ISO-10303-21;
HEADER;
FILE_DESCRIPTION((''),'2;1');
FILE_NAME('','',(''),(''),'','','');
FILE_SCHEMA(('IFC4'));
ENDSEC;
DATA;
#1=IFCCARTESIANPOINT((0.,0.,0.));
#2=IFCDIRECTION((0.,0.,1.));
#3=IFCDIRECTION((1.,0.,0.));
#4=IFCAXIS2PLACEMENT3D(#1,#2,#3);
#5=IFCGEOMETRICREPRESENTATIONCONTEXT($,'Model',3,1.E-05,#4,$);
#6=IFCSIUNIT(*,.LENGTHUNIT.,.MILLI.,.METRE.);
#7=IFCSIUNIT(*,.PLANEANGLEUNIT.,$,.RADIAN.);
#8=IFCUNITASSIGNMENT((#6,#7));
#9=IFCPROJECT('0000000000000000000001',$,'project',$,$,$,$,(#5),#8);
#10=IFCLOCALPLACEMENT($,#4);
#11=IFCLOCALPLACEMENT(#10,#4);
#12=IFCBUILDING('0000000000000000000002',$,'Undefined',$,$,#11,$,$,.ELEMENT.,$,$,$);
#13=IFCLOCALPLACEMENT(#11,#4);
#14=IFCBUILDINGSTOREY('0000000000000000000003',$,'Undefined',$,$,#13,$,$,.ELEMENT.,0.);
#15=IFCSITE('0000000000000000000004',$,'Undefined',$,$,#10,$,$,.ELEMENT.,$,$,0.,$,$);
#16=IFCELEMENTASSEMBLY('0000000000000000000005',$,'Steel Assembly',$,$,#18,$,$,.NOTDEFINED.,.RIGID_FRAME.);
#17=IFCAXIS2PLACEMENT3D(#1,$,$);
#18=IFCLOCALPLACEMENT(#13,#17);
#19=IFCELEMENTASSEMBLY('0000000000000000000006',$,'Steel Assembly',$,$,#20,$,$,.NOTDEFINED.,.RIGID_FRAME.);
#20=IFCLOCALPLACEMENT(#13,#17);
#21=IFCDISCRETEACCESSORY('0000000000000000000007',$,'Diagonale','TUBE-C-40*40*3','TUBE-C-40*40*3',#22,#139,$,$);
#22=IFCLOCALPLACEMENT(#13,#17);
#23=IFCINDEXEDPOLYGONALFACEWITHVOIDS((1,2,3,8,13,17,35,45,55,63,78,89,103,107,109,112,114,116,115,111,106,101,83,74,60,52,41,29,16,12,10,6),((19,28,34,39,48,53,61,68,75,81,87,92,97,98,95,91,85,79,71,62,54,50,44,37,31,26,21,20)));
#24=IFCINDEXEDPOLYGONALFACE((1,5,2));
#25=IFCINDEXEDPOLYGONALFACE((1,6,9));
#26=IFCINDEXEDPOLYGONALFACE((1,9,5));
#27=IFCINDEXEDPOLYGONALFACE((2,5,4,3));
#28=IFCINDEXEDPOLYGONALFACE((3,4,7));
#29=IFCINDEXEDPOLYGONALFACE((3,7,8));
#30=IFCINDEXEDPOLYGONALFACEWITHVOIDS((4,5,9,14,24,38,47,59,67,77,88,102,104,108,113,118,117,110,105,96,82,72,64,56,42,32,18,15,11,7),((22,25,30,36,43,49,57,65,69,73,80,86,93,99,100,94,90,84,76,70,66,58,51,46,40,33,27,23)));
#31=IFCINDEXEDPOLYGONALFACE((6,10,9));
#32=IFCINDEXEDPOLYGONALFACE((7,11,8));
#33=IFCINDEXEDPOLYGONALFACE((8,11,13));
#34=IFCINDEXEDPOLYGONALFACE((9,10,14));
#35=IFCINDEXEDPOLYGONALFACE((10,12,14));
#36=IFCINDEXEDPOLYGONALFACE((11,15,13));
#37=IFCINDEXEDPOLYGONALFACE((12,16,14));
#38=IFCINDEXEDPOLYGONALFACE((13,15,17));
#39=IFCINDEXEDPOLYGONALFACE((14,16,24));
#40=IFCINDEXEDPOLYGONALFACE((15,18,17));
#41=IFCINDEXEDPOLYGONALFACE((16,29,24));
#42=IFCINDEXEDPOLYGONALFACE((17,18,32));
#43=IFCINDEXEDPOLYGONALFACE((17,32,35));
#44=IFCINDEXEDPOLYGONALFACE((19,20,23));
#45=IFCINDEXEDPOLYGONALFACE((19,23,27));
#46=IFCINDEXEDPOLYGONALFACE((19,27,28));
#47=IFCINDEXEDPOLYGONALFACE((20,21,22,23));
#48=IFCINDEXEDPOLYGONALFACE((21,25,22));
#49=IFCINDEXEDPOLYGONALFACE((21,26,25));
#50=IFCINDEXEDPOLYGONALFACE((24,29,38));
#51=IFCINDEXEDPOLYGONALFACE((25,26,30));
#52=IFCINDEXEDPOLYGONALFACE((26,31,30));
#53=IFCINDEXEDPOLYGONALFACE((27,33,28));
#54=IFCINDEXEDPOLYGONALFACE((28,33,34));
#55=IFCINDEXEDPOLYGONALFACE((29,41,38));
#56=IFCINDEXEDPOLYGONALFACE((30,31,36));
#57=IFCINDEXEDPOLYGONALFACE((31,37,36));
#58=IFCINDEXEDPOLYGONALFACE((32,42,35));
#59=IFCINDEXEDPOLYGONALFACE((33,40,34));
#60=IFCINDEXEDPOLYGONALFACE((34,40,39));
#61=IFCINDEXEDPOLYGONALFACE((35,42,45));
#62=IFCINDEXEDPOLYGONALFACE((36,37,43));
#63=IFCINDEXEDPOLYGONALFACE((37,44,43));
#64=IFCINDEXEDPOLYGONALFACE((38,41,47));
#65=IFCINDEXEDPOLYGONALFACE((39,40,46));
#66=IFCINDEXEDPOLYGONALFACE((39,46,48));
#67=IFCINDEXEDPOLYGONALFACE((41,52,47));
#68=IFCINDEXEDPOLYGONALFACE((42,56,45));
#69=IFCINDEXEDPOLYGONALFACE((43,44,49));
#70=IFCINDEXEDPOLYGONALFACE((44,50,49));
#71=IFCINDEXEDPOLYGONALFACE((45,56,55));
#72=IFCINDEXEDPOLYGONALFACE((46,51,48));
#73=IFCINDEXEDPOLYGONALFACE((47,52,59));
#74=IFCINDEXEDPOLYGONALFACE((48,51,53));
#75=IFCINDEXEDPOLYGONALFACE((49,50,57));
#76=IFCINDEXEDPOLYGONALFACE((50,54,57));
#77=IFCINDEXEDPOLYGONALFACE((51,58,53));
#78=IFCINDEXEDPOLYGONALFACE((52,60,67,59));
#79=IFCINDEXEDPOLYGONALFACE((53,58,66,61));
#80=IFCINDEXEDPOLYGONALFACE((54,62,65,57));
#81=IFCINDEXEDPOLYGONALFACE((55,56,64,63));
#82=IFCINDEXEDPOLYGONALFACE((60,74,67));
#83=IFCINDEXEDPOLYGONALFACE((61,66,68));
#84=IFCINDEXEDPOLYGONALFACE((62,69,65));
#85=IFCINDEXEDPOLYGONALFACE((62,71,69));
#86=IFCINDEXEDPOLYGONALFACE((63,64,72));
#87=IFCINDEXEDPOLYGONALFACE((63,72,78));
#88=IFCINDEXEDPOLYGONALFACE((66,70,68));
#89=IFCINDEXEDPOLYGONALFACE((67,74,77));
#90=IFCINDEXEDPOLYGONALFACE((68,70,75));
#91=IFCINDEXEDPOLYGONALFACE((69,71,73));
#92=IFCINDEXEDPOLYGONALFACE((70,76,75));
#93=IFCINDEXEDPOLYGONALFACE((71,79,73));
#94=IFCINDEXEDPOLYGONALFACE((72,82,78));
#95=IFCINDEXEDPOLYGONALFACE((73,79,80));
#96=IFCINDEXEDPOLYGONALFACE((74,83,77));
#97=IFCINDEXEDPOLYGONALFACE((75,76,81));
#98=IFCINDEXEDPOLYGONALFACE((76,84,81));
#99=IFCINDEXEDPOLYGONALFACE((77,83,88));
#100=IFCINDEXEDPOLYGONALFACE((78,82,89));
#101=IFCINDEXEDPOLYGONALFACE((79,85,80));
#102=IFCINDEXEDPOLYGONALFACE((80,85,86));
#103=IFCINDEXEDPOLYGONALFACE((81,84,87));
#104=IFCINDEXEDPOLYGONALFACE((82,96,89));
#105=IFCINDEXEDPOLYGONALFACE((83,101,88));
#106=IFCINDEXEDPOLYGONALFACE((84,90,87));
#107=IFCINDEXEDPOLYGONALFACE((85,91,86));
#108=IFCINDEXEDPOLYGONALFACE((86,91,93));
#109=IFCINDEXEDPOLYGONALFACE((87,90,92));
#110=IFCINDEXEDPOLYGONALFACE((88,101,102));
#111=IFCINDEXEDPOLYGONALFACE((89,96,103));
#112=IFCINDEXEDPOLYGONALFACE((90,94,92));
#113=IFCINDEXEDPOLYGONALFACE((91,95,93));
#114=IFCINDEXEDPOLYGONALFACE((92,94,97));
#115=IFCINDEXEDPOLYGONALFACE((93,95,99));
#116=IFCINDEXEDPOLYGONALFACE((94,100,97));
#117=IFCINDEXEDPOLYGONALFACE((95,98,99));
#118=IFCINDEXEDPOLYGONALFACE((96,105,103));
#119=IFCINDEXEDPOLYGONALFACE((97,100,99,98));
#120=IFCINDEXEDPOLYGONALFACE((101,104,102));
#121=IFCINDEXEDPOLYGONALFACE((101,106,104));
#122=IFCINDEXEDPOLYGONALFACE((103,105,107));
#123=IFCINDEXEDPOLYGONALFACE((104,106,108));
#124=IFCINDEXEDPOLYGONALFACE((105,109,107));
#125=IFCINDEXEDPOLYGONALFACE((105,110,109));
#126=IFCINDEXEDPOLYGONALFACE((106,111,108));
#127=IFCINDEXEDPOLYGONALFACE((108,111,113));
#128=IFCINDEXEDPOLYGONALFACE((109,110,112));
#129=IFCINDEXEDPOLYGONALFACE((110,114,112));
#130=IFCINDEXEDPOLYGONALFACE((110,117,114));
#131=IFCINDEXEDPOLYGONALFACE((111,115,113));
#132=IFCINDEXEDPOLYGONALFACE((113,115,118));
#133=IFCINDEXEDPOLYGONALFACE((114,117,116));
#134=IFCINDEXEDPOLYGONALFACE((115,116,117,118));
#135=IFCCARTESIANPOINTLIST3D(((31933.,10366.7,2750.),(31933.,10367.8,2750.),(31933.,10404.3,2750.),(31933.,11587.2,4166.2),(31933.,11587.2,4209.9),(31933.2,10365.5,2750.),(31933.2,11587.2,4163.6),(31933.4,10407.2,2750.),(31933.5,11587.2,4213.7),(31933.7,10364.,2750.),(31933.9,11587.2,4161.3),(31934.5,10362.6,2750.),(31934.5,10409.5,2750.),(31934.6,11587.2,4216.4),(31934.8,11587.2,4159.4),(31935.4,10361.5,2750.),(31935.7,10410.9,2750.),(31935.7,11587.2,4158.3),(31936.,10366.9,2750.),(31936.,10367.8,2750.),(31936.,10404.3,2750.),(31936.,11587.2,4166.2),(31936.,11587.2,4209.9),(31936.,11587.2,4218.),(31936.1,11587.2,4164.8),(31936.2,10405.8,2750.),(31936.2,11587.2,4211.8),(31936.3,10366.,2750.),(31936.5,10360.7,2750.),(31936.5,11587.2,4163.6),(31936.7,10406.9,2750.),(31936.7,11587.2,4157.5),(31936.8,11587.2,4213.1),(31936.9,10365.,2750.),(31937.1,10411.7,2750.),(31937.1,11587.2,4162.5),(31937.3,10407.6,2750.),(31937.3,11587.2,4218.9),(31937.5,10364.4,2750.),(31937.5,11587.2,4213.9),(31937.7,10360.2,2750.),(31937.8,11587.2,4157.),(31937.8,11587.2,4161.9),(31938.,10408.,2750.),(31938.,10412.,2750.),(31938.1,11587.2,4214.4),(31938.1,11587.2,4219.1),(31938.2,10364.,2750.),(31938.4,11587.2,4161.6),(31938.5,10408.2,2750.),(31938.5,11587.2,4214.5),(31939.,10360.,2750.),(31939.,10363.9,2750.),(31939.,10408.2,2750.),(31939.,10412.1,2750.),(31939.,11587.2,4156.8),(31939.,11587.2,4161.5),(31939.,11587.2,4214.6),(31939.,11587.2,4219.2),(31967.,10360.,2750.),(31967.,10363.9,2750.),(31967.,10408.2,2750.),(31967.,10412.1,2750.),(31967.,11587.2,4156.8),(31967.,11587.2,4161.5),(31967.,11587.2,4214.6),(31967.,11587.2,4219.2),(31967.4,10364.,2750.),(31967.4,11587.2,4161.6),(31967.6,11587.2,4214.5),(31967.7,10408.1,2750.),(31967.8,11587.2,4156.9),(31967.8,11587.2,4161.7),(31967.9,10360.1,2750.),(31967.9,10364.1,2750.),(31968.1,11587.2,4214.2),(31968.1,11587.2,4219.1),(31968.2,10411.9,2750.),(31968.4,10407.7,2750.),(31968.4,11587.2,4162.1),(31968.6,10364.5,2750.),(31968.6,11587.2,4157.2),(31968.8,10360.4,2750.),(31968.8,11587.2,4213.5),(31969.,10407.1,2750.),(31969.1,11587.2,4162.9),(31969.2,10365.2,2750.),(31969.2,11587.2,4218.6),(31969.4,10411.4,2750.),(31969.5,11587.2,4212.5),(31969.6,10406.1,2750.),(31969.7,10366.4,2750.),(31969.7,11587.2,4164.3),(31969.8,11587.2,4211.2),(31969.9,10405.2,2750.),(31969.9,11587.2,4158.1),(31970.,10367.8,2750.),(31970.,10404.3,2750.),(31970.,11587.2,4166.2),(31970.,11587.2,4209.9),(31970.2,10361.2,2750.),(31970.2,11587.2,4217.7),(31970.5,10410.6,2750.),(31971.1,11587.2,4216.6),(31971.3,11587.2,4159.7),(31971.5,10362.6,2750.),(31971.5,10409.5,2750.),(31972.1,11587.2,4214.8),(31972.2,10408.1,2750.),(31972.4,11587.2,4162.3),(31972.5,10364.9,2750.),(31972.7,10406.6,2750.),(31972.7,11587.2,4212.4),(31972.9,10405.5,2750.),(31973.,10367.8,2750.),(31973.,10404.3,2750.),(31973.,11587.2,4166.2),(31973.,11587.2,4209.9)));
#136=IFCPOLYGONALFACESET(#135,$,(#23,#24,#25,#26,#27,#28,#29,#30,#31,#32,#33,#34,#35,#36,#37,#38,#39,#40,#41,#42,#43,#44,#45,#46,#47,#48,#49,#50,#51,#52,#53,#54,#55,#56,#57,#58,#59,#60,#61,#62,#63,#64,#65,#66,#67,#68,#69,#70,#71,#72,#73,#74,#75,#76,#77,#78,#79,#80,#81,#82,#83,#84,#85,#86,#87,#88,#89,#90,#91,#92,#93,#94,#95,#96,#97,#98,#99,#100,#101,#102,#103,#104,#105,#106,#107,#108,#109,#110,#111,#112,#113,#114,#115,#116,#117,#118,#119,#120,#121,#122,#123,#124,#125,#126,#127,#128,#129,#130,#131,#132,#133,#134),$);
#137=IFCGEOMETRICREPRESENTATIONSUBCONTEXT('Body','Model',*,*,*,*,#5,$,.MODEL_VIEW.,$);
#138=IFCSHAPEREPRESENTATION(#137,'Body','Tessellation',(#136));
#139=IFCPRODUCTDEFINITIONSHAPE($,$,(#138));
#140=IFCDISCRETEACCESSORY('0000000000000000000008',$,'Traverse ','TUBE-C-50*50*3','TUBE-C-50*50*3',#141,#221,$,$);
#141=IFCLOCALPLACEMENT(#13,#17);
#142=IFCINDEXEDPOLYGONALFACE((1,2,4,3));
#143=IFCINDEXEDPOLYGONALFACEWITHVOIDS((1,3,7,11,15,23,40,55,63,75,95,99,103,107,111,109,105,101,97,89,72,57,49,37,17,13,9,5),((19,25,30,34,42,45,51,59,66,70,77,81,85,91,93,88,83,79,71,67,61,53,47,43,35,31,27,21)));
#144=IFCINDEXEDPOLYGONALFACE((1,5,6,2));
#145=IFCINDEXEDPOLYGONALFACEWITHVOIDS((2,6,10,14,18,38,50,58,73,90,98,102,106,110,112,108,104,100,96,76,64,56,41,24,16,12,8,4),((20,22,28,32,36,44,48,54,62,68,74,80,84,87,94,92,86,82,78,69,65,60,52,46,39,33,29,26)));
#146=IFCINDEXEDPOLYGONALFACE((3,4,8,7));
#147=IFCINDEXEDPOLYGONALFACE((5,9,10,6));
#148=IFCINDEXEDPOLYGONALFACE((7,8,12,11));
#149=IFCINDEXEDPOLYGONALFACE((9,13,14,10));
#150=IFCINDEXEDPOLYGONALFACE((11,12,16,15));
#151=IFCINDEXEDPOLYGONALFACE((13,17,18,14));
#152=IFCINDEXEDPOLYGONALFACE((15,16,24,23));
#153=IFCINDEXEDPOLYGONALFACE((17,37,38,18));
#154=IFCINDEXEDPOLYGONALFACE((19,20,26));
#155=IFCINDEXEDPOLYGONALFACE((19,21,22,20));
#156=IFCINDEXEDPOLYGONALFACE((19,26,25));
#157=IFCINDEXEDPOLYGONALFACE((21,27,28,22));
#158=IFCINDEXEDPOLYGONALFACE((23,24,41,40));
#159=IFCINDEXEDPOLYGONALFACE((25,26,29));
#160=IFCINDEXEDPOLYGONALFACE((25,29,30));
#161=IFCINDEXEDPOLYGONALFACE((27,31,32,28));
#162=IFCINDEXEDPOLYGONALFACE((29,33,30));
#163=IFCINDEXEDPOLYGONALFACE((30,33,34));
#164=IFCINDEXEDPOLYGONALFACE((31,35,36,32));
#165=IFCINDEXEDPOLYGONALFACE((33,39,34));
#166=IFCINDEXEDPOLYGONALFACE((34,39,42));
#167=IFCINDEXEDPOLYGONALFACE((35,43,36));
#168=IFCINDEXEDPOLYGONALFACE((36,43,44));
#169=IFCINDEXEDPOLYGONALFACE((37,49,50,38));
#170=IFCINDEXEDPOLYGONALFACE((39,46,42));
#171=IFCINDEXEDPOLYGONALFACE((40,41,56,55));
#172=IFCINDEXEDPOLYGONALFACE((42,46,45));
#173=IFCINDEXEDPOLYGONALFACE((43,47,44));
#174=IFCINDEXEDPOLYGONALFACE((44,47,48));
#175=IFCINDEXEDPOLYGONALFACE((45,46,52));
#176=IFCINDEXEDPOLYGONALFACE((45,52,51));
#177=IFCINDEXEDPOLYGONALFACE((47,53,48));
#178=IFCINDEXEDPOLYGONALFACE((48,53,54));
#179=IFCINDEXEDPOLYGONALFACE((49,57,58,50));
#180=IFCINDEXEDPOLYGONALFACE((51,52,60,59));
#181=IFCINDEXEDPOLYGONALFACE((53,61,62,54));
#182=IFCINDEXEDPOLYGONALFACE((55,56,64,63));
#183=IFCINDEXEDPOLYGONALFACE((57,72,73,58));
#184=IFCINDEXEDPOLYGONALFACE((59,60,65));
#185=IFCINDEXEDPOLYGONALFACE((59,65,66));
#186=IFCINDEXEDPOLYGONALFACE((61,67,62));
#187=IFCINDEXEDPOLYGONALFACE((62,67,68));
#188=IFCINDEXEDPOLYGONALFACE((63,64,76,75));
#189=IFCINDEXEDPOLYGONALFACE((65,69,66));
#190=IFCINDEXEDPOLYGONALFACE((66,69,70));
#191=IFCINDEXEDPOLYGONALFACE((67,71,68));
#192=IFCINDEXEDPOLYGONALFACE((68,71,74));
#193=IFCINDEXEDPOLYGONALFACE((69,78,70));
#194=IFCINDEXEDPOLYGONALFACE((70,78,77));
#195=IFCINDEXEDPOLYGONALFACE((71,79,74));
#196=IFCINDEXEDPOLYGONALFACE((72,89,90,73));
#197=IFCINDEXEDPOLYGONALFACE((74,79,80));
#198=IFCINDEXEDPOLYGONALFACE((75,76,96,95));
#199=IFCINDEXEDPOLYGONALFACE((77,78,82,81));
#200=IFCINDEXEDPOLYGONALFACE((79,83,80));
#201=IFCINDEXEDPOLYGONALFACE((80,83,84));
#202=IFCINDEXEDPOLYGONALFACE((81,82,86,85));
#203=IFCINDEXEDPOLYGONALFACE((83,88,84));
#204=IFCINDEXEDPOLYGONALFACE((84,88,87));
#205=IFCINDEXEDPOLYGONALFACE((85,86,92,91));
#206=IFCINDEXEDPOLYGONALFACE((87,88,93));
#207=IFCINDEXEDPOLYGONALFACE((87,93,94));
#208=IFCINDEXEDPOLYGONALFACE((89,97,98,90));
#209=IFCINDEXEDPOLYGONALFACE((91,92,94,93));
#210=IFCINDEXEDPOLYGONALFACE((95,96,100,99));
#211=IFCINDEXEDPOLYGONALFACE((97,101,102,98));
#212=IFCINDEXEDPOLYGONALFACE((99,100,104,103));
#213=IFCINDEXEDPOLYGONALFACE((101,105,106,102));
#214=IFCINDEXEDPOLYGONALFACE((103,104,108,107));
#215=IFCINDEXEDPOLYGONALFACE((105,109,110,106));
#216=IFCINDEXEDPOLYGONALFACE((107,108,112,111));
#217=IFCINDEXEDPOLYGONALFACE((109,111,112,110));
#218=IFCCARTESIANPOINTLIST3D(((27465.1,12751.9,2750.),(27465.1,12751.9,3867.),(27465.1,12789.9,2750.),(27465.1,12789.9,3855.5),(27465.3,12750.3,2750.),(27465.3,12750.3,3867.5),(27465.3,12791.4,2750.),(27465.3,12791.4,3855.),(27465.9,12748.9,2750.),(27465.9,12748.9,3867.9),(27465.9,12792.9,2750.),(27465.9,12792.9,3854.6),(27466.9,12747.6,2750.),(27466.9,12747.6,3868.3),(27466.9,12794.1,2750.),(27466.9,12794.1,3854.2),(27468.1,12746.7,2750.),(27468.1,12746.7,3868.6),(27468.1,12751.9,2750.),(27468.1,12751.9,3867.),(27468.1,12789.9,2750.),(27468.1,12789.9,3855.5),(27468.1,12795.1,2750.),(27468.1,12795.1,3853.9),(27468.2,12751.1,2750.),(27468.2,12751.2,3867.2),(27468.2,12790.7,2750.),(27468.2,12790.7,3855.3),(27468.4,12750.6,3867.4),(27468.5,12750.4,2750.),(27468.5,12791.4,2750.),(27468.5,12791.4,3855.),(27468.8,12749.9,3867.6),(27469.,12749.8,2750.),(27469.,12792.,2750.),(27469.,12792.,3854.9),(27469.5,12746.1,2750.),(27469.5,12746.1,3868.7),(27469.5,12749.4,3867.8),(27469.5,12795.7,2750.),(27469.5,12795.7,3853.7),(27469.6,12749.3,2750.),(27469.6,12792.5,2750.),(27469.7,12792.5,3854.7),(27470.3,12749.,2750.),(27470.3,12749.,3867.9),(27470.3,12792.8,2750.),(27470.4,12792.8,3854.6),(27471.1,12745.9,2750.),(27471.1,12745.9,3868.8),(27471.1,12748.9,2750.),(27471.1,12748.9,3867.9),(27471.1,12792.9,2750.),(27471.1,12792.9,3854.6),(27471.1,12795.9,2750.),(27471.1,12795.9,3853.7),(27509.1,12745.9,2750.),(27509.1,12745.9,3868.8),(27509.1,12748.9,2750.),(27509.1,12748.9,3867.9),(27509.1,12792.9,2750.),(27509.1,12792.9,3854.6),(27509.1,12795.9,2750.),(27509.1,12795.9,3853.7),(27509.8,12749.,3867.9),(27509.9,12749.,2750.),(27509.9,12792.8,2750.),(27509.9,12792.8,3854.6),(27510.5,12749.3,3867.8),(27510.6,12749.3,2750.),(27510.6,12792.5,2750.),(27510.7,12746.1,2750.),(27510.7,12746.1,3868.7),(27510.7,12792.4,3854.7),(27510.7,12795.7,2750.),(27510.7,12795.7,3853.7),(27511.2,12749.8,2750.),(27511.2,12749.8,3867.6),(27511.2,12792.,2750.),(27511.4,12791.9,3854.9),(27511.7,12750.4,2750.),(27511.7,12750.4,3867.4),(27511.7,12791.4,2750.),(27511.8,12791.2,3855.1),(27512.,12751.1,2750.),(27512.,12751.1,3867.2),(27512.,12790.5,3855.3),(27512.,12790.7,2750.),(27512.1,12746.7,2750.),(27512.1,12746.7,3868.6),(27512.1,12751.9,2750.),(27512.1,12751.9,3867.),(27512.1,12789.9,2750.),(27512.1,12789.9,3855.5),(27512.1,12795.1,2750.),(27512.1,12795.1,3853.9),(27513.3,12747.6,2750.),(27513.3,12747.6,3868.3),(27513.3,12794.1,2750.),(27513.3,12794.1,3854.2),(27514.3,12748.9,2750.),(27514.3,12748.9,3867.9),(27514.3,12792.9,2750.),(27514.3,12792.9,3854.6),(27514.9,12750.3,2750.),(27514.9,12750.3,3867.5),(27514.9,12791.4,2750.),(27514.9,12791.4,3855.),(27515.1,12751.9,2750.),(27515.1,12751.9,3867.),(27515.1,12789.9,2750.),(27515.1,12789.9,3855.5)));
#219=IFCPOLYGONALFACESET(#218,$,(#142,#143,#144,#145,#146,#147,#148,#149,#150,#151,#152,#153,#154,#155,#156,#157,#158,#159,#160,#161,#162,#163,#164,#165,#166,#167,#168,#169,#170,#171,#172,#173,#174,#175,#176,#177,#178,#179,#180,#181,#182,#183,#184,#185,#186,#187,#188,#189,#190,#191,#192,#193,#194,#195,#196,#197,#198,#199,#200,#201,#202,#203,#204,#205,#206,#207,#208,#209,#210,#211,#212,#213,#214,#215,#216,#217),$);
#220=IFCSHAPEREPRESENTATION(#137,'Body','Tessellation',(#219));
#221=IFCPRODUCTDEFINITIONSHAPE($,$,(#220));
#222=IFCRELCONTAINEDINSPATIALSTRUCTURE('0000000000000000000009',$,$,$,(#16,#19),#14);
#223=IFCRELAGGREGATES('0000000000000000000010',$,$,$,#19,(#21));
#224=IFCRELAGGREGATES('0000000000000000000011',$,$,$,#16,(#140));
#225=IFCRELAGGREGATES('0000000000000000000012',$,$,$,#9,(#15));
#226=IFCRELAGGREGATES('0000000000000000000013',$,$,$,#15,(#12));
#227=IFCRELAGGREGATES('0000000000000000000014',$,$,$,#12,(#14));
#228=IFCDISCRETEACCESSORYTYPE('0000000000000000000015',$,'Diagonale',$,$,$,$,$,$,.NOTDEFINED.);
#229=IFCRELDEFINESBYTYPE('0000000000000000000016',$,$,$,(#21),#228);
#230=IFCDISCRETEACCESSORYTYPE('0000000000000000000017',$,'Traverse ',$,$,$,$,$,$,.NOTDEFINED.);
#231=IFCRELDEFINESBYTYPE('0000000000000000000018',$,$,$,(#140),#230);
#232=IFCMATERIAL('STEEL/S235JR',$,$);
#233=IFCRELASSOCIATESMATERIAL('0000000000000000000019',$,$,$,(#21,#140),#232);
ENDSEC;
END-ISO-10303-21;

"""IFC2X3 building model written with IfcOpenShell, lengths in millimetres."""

from ifc_helpers import new_model, si_unit, frame, origin_with_axes, origin_2d_with_axis, place, context, subcontext, project, spatial, hollow_rectangle, extrude, clip, halfspace, material, type_object, element, aggregate, save


model = new_model("IFC2X3")

# Units and contexts
model_context = context("Model", 3, precision=1e-05, world=origin_with_axes())
body_context = subcontext(model_context, "Body", "Model", "MODEL_VIEW")
ifc_project = project(units=[si_unit("LENGTHUNIT", "METRE", prefix="MILLI"), si_unit("PLANEANGLEUNIT", "RADIAN")], contexts=[model_context])

# Site, building, storey
site_placement = place(None, origin_with_axes())
site = spatial("IfcSite", under=ifc_project, at=site_placement, Name="Undefined", CompositionType="ELEMENT", RefElevation=0.0)
building_placement = place(site_placement, origin_with_axes())
building = spatial("IfcBuilding", under=site, at=building_placement, Name="Undefined", CompositionType="ELEMENT")
storey_placement = place(building_placement, origin_with_axes())
storey = spatial("IfcBuildingStorey", under=building, at=storey_placement, Name="Undefined", CompositionType="ELEMENT", Elevation=0.0)

# Element assemblies, discrete accessory
assembly_1_placement = place(storey_placement, origin_with_axes())
assembly_1 = element("IfcElementAssembly", 1, at=assembly_1_placement, inside=storey, Name="Steel Assembly", AssemblyPlace="NOTDEFINED", PredefinedType="RIGID_FRAME")
ifc_material_1 = material(Name="STEEL/S235JR")
discrete_accessory_type_1 = type_object("IfcDiscreteAccessoryType", Name="Diagonale")
assembly_2_placement = place(storey_placement, origin_with_axes())
assembly_2 = element("IfcElementAssembly", 2, at=assembly_2_placement, inside=storey, Name="Steel Assembly", AssemblyPlace="NOTDEFINED", PredefinedType="RIGID_FRAME")
discrete_accessory_1_placement = place(assembly_2_placement, frame((31953.0, 10375.3, 2737.2), z_axis=(0.0, -0.767483, 0.64107), x_axis=(0.0, 0.64107, 0.767483)))
discrete_accessory_1 = element("IfcDiscreteAccessory", 3, at=discrete_accessory_1_placement, type_object=discrete_accessory_type_1, material=ifc_material_1, Name="Diagonale", Description="TUBE-C-40*40*3", ObjectType="TUBE-C-40*40*3", context=body_context, shape_type="Clipping", body=[
    clip(clip(extrude(hollow_rectangle(XDim=40.0, YDim=40.0, WallThickness=3.0, InnerFilletRadius=3.0, OuterFilletRadius=6.0, at=origin_2d_with_axis()), frame((1931.5, 0.0, 0.0), z_axis=(-1.0, 0.0, 0.0), x_axis=(0.0, -1.0, 0.0)), (0.0, 0.0, 1.0), 1955.8), halfspace(frame((1843.1, 0.0, -39.5), z_axis=(0.64107, 0.0, -0.767483), x_axis=(0.0, -1.0, 0.0)), False)), halfspace(frame((17.2, 0.0, -0.6), z_axis=(-0.767483, 0.0, -0.64107), x_axis=(0.0, -1.0, 0.0)), False)),
])
aggregate(assembly_2, [discrete_accessory_1])

# Discrete accessory
discrete_accessory_type_2 = type_object("IfcDiscreteAccessoryType", Name="Traverse ")
discrete_accessory_2_placement = place(assembly_1_placement, frame((27490.1, 12770.9, 3861.2), z_axis=(0.0, 1.0, 0.0), x_axis=(0.0, 0.0, -1.0)))
discrete_accessory_2 = element("IfcDiscreteAccessory", 4, at=discrete_accessory_2_placement, type_object=discrete_accessory_type_2, material=ifc_material_1, Name="Traverse ", Description="TUBE-C-50*50*3", ObjectType="TUBE-C-50*50*3", context=body_context, shape_type="Clipping", body=[
    clip(extrude(hollow_rectangle(XDim=50.0, YDim=50.0, WallThickness=3.0, InnerFilletRadius=3.0, OuterFilletRadius=6.0, at=origin_2d_with_axis()), frame((1111.2, 0.0, 0.0), z_axis=(-1.0, 0.0, 0.0), x_axis=(0.0, -1.0, 0.0)), (0.0, 0.0, 1.0), 1118.9), halfspace(frame((-13.3, 0.0, -44.0), z_axis=(0.957179, 0.0, -0.289497), x_axis=(0.0, -1.0, 0.0)), True)),
])
aggregate(assembly_1, [discrete_accessory_2])

save(model, "model.ifc")
